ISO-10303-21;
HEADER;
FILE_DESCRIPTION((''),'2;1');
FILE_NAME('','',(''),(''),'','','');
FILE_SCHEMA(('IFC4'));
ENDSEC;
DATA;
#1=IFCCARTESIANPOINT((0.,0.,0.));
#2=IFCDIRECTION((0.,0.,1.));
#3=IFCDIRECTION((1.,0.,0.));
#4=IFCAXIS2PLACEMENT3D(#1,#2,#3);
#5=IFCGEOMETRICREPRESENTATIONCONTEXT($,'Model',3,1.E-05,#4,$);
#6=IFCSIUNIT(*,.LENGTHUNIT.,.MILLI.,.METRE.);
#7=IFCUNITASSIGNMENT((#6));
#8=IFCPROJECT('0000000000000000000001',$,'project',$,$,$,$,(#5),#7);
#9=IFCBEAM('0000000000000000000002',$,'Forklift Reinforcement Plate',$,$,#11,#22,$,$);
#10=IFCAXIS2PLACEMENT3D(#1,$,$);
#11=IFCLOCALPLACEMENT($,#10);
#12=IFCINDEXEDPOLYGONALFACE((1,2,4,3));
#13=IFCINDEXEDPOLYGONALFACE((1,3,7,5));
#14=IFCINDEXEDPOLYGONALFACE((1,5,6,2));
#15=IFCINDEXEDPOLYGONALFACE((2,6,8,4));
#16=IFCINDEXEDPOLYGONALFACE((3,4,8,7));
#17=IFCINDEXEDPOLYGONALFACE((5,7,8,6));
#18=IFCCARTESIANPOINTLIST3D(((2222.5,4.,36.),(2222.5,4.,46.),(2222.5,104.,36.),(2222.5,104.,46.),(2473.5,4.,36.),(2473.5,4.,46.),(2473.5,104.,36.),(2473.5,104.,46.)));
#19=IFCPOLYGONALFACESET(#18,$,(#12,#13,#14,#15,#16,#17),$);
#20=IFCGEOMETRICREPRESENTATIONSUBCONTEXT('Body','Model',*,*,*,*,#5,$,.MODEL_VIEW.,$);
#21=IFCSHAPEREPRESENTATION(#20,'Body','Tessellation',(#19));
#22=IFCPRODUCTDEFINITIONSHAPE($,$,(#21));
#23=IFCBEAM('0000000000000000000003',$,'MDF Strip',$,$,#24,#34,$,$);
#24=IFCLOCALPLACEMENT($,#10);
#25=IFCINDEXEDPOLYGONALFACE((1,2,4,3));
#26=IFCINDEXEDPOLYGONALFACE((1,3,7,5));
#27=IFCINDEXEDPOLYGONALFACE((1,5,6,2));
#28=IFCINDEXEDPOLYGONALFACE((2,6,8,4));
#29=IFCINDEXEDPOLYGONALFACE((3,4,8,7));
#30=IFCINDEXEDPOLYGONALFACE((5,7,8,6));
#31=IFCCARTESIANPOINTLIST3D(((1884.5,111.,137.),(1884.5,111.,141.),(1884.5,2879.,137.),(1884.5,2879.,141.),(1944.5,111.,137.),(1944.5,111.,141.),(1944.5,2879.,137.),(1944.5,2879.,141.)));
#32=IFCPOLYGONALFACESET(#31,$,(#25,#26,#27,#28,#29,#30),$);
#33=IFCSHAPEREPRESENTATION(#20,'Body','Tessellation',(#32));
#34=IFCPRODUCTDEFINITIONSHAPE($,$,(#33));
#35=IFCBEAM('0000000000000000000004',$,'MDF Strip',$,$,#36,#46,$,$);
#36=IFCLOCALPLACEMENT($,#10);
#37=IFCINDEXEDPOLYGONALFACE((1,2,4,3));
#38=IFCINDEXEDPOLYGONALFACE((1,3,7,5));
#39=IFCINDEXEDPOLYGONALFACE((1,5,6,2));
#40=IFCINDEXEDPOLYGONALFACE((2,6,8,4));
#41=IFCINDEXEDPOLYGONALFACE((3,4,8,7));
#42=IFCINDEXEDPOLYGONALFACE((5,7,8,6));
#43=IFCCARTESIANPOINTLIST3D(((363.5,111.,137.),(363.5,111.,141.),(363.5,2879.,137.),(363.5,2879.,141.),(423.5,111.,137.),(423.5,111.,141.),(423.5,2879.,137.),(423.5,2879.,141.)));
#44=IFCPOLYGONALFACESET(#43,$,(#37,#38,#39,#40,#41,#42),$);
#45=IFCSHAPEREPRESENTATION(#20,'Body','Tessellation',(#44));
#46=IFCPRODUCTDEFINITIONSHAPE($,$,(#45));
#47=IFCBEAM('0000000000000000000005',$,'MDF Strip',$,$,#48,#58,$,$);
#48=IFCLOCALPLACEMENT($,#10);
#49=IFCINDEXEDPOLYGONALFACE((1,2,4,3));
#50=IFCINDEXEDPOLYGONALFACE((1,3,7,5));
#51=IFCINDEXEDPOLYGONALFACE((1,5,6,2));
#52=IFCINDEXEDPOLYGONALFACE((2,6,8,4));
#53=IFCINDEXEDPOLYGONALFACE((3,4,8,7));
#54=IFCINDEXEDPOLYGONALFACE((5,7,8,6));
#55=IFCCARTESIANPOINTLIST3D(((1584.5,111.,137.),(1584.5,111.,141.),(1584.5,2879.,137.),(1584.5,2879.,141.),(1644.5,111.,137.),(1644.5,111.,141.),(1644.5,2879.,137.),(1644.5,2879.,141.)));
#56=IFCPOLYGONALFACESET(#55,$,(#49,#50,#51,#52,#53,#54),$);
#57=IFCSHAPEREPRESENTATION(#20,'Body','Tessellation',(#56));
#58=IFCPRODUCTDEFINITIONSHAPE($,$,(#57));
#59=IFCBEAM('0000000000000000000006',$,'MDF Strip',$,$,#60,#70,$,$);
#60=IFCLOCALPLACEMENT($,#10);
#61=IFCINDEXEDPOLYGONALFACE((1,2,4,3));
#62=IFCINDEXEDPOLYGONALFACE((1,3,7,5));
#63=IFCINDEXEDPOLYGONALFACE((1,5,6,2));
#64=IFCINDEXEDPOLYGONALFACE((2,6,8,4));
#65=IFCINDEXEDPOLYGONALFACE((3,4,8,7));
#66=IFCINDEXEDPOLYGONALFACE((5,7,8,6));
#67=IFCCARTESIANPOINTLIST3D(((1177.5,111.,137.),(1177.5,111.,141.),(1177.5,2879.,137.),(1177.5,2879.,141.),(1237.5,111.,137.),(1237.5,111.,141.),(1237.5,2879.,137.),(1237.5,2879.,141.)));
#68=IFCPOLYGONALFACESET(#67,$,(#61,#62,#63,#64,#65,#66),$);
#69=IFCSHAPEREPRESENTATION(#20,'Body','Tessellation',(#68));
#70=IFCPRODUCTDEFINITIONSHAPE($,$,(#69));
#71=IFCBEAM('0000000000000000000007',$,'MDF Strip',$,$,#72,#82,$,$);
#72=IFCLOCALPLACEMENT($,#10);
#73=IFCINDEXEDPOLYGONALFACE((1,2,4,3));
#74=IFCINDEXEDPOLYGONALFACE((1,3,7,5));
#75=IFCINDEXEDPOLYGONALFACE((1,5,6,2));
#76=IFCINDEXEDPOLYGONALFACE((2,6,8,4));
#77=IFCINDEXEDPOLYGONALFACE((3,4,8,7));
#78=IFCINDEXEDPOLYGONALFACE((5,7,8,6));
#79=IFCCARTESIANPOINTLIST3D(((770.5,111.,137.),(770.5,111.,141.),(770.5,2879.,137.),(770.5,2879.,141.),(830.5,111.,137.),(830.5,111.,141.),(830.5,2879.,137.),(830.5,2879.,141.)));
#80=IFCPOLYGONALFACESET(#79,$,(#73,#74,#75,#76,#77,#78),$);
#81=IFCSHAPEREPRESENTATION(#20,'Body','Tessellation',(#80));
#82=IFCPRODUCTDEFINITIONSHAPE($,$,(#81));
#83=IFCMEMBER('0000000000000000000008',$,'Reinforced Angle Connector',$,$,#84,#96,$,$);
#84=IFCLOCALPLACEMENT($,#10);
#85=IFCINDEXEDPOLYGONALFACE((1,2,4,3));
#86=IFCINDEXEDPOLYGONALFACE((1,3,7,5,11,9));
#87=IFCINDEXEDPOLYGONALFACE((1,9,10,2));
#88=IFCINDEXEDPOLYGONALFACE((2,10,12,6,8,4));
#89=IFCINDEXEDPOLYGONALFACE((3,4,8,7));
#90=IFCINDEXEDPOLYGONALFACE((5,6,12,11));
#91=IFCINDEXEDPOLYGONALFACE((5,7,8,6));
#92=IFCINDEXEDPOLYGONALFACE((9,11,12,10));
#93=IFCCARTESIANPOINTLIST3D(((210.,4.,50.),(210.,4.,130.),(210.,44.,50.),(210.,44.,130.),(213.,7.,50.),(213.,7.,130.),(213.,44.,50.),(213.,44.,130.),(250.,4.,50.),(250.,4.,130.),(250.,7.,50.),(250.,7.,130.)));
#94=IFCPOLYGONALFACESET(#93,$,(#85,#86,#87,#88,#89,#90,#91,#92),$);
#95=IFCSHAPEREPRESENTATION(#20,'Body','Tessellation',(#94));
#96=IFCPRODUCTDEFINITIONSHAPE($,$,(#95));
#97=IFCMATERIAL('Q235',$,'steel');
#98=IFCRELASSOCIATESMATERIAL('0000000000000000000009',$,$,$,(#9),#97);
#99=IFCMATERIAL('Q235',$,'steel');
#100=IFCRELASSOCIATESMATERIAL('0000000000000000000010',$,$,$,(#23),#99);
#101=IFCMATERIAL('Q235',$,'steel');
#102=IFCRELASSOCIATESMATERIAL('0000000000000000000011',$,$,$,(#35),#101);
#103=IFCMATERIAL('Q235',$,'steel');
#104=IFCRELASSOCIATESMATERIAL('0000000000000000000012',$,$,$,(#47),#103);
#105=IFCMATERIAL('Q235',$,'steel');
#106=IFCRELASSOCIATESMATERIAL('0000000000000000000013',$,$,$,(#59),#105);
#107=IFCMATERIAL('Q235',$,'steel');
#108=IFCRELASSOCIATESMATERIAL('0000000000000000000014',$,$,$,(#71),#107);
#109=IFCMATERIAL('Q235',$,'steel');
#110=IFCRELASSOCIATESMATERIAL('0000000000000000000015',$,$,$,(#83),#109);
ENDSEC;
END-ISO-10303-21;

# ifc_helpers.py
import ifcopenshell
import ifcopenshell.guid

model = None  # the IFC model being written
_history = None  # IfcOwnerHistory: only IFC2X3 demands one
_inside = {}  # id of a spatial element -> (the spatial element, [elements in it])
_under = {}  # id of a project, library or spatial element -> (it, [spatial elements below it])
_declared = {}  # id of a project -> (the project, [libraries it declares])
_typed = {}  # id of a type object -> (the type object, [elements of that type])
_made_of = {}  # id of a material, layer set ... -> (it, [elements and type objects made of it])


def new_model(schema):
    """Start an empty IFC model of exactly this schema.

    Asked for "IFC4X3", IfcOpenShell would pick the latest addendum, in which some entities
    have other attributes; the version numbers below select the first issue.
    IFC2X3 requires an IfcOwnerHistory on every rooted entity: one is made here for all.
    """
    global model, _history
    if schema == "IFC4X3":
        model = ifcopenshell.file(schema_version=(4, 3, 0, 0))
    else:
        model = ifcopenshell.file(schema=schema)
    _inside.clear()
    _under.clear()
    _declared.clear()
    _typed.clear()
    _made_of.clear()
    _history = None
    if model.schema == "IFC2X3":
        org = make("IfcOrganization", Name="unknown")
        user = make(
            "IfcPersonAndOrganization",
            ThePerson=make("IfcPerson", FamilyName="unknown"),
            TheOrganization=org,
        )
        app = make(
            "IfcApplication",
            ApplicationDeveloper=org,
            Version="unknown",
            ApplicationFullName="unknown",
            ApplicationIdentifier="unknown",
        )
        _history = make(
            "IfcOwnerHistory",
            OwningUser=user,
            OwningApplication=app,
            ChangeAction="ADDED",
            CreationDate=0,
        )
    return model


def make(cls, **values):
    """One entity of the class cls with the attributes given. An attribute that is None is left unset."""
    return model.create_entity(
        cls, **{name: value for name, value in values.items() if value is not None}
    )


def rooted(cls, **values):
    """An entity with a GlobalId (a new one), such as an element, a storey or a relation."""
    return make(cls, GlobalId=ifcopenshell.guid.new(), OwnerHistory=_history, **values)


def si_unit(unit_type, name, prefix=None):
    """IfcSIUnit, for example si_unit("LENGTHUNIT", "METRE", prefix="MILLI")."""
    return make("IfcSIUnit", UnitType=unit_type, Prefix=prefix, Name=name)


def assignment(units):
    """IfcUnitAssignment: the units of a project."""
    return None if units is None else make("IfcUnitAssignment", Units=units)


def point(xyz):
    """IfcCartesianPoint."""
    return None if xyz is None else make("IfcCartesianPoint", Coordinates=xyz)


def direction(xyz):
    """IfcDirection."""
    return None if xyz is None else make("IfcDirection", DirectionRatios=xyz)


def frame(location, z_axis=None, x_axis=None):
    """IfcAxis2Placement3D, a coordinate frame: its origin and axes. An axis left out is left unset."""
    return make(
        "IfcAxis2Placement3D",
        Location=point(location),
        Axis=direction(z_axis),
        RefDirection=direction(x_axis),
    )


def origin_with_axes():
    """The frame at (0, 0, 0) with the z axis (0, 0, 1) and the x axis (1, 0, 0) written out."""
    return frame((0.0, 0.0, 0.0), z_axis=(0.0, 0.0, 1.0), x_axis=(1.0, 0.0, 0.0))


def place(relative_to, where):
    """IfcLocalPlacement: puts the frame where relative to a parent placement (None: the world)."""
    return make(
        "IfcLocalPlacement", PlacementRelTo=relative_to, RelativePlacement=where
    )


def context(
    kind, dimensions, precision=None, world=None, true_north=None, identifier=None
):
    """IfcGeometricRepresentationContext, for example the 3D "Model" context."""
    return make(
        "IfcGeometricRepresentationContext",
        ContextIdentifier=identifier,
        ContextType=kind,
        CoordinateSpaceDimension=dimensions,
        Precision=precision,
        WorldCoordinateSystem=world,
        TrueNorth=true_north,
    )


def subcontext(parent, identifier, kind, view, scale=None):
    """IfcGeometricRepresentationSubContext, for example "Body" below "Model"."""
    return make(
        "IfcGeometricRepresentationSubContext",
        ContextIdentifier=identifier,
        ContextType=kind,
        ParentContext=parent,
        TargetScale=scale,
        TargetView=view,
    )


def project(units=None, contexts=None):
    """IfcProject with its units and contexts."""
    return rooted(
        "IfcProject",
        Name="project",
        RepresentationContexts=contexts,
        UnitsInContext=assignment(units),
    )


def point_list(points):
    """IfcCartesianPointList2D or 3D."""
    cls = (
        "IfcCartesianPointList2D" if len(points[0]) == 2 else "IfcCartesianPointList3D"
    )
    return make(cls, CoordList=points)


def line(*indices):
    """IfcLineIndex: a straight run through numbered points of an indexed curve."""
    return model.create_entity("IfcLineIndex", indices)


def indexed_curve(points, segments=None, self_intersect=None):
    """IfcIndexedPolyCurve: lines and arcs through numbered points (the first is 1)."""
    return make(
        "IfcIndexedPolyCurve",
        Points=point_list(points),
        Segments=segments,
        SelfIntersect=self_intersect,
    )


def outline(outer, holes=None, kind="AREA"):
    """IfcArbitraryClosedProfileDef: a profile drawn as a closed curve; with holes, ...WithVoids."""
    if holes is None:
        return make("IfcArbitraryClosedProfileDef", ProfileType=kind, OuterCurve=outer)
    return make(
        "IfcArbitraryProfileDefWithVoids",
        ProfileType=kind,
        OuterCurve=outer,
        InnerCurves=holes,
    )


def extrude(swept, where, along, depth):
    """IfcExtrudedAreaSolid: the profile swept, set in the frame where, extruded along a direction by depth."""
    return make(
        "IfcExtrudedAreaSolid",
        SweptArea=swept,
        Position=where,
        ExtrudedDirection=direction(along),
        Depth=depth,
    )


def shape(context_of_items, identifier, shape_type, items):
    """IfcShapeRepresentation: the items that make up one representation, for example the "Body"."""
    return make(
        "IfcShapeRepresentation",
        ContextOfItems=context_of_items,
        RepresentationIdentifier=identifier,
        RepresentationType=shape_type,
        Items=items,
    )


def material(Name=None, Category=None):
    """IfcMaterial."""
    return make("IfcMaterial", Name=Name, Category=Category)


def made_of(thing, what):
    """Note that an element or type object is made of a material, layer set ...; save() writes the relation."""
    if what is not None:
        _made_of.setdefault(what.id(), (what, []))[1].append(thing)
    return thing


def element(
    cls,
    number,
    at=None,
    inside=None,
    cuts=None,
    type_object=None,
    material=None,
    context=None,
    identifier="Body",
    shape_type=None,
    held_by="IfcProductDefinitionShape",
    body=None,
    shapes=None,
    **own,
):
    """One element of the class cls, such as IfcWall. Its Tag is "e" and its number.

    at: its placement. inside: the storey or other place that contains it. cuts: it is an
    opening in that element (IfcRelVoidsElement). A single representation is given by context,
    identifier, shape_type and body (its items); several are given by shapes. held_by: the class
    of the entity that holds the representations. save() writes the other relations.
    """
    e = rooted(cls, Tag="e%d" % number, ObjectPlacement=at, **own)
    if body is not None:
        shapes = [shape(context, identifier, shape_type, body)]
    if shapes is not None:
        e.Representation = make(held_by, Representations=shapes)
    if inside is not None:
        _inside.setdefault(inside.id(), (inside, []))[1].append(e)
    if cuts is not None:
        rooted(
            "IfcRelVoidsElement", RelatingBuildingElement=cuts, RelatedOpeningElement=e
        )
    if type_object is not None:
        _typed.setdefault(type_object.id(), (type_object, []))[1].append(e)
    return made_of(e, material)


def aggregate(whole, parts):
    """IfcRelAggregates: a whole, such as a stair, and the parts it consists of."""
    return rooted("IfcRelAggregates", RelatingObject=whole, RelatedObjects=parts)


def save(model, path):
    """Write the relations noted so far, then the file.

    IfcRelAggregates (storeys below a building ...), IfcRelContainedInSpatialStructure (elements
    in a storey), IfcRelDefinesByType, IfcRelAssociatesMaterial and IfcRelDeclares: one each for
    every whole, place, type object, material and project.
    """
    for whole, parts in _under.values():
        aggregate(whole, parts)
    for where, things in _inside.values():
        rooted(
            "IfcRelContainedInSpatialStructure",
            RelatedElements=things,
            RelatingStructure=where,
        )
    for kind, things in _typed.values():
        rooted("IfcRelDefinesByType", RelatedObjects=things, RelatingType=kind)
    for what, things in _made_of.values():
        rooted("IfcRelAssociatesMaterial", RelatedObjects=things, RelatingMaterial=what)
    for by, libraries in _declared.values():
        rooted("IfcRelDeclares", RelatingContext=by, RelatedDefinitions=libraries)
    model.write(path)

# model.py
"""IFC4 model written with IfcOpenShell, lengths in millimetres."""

from ifc_helpers import new_model, si_unit, frame, origin_with_axes, place, context, subcontext, project, line, indexed_curve, outline, extrude, material, element, save


model = new_model("IFC4")

# Units and contexts
model_context = context("Model", 3, precision=1e-05, world=origin_with_axes())
body_context = subcontext(model_context, "Body", "Model", "MODEL_VIEW")
ifc_project = project(units=[si_unit("LENGTHUNIT", "METRE", prefix="MILLI")], contexts=[model_context])

# Beams
ifc_material_1 = material(Name="Q235", Category="steel")
beam_1_placement = place(None, frame((2222.5, 4.0, 36.0), z_axis=(0.0, 0.0, 1.0), x_axis=(1.0, 0.0, 0.0)))
element("IfcBeam", 1, at=beam_1_placement, material=ifc_material_1, Name="Forklift Reinforcement Plate", context=body_context, shape_type="SweptSolid", body=[
    extrude(outline(indexed_curve([(0.0, 0.0), (0.0, 100.0), (251.0, 100.0), (251.0, 0.0), (0.0, 0.0)], segments=[line(1, 2, 3, 4, 5, 1)])), origin_with_axes(), (0.0, 0.0, 1.0), 10.0),
])
ifc_material_2 = material(Name="Q235", Category="steel")
beam_2_placement = place(None, frame((1884.5, 111.0, 137.0), z_axis=(0.0, 1.0, 0.0), x_axis=(1.0, 0.0, 0.0)))
element("IfcBeam", 2, at=beam_2_placement, material=ifc_material_2, Name="MDF Strip", context=body_context, shape_type="SweptSolid", body=[
    extrude(outline(indexed_curve([(0.0, 0.0), (60.0, 0.0), (60.0, -4.0), (0.0, -4.0), (0.0, 0.0)], segments=[line(1, 2, 3, 4, 5, 1)])), origin_with_axes(), (0.0, 0.0, 1.0), 2768.0),
])
ifc_material_3 = material(Name="Q235", Category="steel")
beam_3_placement = place(None, frame((363.5, 111.0, 137.0), z_axis=(0.0, 1.0, 0.0), x_axis=(1.0, 0.0, 0.0)))
element("IfcBeam", 3, at=beam_3_placement, material=ifc_material_3, Name="MDF Strip", context=body_context, shape_type="SweptSolid", body=[
    extrude(outline(indexed_curve([(0.0, 0.0), (60.0, 0.0), (60.0, -4.0), (0.0, -4.0), (0.0, 0.0)], segments=[line(1, 2, 3, 4, 5, 1)])), origin_with_axes(), (0.0, 0.0, 1.0), 2768.0),
])
ifc_material_4 = material(Name="Q235", Category="steel")
beam_4_placement = place(None, frame((1584.5, 111.0, 137.0), z_axis=(0.0, 1.0, 0.0), x_axis=(1.0, 0.0, 0.0)))
element("IfcBeam", 4, at=beam_4_placement, material=ifc_material_4, Name="MDF Strip", context=body_context, shape_type="SweptSolid", body=[
    extrude(outline(indexed_curve([(0.0, 0.0), (60.0, 0.0), (60.0, -4.0), (0.0, -4.0), (0.0, 0.0)], segments=[line(1, 2, 3, 4, 5, 1)])), origin_with_axes(), (0.0, 0.0, 1.0), 2768.0),
])
ifc_material_5 = material(Name="Q235", Category="steel")
beam_5_placement = place(None, frame((1177.5, 111.0, 137.0), z_axis=(0.0, 1.0, 0.0), x_axis=(1.0, 0.0, 0.0)))
element("IfcBeam", 5, at=beam_5_placement, material=ifc_material_5, Name="MDF Strip", context=body_context, shape_type="SweptSolid", body=[
    extrude(outline(indexed_curve([(0.0, 0.0), (60.0, 0.0), (60.0, -4.0), (0.0, -4.0), (0.0, 0.0)], segments=[line(1, 2, 3, 4, 5, 1)])), origin_with_axes(), (0.0, 0.0, 1.0), 2768.0),
])
ifc_material_6 = material(Name="Q235", Category="steel")
beam_6_placement = place(None, frame((770.5, 111.0, 137.0), z_axis=(0.0, 1.0, 0.0), x_axis=(1.0, 0.0, 0.0)))
element("IfcBeam", 6, at=beam_6_placement, material=ifc_material_6, Name="MDF Strip", context=body_context, shape_type="SweptSolid", body=[
    extrude(outline(indexed_curve([(0.0, 0.0), (60.0, 0.0), (60.0, -4.0), (0.0, -4.0), (0.0, 0.0)], segments=[line(1, 2, 3, 4, 5, 1)])), origin_with_axes(), (0.0, 0.0, 1.0), 2768.0),
])

# Member
ifc_material_7 = material(Name="Q235", Category="steel")
member_1_placement = place(None, frame((210.0, 4.0, 50.0), z_axis=(0.0, 0.0, 1.0), x_axis=(1.0, 0.0, 0.0)))
element("IfcMember", 7, at=member_1_placement, material=ifc_material_7, Name="Reinforced Angle Connector", context=body_context, shape_type="SweptSolid", body=[
    extrude(outline(indexed_curve([(0.0, 0.0), (0.0, 40.0), (3.0, 40.0), (3.0, 3.0), (40.0, 3.0), (40.0, 0.0), (0.0, 0.0)], segments=[line(1, 2, 3, 4, 5, 6, 7, 1)])), origin_with_axes(), (0.0, 0.0, 1.0), 80.0),
])

save(model, "model.ifc")
